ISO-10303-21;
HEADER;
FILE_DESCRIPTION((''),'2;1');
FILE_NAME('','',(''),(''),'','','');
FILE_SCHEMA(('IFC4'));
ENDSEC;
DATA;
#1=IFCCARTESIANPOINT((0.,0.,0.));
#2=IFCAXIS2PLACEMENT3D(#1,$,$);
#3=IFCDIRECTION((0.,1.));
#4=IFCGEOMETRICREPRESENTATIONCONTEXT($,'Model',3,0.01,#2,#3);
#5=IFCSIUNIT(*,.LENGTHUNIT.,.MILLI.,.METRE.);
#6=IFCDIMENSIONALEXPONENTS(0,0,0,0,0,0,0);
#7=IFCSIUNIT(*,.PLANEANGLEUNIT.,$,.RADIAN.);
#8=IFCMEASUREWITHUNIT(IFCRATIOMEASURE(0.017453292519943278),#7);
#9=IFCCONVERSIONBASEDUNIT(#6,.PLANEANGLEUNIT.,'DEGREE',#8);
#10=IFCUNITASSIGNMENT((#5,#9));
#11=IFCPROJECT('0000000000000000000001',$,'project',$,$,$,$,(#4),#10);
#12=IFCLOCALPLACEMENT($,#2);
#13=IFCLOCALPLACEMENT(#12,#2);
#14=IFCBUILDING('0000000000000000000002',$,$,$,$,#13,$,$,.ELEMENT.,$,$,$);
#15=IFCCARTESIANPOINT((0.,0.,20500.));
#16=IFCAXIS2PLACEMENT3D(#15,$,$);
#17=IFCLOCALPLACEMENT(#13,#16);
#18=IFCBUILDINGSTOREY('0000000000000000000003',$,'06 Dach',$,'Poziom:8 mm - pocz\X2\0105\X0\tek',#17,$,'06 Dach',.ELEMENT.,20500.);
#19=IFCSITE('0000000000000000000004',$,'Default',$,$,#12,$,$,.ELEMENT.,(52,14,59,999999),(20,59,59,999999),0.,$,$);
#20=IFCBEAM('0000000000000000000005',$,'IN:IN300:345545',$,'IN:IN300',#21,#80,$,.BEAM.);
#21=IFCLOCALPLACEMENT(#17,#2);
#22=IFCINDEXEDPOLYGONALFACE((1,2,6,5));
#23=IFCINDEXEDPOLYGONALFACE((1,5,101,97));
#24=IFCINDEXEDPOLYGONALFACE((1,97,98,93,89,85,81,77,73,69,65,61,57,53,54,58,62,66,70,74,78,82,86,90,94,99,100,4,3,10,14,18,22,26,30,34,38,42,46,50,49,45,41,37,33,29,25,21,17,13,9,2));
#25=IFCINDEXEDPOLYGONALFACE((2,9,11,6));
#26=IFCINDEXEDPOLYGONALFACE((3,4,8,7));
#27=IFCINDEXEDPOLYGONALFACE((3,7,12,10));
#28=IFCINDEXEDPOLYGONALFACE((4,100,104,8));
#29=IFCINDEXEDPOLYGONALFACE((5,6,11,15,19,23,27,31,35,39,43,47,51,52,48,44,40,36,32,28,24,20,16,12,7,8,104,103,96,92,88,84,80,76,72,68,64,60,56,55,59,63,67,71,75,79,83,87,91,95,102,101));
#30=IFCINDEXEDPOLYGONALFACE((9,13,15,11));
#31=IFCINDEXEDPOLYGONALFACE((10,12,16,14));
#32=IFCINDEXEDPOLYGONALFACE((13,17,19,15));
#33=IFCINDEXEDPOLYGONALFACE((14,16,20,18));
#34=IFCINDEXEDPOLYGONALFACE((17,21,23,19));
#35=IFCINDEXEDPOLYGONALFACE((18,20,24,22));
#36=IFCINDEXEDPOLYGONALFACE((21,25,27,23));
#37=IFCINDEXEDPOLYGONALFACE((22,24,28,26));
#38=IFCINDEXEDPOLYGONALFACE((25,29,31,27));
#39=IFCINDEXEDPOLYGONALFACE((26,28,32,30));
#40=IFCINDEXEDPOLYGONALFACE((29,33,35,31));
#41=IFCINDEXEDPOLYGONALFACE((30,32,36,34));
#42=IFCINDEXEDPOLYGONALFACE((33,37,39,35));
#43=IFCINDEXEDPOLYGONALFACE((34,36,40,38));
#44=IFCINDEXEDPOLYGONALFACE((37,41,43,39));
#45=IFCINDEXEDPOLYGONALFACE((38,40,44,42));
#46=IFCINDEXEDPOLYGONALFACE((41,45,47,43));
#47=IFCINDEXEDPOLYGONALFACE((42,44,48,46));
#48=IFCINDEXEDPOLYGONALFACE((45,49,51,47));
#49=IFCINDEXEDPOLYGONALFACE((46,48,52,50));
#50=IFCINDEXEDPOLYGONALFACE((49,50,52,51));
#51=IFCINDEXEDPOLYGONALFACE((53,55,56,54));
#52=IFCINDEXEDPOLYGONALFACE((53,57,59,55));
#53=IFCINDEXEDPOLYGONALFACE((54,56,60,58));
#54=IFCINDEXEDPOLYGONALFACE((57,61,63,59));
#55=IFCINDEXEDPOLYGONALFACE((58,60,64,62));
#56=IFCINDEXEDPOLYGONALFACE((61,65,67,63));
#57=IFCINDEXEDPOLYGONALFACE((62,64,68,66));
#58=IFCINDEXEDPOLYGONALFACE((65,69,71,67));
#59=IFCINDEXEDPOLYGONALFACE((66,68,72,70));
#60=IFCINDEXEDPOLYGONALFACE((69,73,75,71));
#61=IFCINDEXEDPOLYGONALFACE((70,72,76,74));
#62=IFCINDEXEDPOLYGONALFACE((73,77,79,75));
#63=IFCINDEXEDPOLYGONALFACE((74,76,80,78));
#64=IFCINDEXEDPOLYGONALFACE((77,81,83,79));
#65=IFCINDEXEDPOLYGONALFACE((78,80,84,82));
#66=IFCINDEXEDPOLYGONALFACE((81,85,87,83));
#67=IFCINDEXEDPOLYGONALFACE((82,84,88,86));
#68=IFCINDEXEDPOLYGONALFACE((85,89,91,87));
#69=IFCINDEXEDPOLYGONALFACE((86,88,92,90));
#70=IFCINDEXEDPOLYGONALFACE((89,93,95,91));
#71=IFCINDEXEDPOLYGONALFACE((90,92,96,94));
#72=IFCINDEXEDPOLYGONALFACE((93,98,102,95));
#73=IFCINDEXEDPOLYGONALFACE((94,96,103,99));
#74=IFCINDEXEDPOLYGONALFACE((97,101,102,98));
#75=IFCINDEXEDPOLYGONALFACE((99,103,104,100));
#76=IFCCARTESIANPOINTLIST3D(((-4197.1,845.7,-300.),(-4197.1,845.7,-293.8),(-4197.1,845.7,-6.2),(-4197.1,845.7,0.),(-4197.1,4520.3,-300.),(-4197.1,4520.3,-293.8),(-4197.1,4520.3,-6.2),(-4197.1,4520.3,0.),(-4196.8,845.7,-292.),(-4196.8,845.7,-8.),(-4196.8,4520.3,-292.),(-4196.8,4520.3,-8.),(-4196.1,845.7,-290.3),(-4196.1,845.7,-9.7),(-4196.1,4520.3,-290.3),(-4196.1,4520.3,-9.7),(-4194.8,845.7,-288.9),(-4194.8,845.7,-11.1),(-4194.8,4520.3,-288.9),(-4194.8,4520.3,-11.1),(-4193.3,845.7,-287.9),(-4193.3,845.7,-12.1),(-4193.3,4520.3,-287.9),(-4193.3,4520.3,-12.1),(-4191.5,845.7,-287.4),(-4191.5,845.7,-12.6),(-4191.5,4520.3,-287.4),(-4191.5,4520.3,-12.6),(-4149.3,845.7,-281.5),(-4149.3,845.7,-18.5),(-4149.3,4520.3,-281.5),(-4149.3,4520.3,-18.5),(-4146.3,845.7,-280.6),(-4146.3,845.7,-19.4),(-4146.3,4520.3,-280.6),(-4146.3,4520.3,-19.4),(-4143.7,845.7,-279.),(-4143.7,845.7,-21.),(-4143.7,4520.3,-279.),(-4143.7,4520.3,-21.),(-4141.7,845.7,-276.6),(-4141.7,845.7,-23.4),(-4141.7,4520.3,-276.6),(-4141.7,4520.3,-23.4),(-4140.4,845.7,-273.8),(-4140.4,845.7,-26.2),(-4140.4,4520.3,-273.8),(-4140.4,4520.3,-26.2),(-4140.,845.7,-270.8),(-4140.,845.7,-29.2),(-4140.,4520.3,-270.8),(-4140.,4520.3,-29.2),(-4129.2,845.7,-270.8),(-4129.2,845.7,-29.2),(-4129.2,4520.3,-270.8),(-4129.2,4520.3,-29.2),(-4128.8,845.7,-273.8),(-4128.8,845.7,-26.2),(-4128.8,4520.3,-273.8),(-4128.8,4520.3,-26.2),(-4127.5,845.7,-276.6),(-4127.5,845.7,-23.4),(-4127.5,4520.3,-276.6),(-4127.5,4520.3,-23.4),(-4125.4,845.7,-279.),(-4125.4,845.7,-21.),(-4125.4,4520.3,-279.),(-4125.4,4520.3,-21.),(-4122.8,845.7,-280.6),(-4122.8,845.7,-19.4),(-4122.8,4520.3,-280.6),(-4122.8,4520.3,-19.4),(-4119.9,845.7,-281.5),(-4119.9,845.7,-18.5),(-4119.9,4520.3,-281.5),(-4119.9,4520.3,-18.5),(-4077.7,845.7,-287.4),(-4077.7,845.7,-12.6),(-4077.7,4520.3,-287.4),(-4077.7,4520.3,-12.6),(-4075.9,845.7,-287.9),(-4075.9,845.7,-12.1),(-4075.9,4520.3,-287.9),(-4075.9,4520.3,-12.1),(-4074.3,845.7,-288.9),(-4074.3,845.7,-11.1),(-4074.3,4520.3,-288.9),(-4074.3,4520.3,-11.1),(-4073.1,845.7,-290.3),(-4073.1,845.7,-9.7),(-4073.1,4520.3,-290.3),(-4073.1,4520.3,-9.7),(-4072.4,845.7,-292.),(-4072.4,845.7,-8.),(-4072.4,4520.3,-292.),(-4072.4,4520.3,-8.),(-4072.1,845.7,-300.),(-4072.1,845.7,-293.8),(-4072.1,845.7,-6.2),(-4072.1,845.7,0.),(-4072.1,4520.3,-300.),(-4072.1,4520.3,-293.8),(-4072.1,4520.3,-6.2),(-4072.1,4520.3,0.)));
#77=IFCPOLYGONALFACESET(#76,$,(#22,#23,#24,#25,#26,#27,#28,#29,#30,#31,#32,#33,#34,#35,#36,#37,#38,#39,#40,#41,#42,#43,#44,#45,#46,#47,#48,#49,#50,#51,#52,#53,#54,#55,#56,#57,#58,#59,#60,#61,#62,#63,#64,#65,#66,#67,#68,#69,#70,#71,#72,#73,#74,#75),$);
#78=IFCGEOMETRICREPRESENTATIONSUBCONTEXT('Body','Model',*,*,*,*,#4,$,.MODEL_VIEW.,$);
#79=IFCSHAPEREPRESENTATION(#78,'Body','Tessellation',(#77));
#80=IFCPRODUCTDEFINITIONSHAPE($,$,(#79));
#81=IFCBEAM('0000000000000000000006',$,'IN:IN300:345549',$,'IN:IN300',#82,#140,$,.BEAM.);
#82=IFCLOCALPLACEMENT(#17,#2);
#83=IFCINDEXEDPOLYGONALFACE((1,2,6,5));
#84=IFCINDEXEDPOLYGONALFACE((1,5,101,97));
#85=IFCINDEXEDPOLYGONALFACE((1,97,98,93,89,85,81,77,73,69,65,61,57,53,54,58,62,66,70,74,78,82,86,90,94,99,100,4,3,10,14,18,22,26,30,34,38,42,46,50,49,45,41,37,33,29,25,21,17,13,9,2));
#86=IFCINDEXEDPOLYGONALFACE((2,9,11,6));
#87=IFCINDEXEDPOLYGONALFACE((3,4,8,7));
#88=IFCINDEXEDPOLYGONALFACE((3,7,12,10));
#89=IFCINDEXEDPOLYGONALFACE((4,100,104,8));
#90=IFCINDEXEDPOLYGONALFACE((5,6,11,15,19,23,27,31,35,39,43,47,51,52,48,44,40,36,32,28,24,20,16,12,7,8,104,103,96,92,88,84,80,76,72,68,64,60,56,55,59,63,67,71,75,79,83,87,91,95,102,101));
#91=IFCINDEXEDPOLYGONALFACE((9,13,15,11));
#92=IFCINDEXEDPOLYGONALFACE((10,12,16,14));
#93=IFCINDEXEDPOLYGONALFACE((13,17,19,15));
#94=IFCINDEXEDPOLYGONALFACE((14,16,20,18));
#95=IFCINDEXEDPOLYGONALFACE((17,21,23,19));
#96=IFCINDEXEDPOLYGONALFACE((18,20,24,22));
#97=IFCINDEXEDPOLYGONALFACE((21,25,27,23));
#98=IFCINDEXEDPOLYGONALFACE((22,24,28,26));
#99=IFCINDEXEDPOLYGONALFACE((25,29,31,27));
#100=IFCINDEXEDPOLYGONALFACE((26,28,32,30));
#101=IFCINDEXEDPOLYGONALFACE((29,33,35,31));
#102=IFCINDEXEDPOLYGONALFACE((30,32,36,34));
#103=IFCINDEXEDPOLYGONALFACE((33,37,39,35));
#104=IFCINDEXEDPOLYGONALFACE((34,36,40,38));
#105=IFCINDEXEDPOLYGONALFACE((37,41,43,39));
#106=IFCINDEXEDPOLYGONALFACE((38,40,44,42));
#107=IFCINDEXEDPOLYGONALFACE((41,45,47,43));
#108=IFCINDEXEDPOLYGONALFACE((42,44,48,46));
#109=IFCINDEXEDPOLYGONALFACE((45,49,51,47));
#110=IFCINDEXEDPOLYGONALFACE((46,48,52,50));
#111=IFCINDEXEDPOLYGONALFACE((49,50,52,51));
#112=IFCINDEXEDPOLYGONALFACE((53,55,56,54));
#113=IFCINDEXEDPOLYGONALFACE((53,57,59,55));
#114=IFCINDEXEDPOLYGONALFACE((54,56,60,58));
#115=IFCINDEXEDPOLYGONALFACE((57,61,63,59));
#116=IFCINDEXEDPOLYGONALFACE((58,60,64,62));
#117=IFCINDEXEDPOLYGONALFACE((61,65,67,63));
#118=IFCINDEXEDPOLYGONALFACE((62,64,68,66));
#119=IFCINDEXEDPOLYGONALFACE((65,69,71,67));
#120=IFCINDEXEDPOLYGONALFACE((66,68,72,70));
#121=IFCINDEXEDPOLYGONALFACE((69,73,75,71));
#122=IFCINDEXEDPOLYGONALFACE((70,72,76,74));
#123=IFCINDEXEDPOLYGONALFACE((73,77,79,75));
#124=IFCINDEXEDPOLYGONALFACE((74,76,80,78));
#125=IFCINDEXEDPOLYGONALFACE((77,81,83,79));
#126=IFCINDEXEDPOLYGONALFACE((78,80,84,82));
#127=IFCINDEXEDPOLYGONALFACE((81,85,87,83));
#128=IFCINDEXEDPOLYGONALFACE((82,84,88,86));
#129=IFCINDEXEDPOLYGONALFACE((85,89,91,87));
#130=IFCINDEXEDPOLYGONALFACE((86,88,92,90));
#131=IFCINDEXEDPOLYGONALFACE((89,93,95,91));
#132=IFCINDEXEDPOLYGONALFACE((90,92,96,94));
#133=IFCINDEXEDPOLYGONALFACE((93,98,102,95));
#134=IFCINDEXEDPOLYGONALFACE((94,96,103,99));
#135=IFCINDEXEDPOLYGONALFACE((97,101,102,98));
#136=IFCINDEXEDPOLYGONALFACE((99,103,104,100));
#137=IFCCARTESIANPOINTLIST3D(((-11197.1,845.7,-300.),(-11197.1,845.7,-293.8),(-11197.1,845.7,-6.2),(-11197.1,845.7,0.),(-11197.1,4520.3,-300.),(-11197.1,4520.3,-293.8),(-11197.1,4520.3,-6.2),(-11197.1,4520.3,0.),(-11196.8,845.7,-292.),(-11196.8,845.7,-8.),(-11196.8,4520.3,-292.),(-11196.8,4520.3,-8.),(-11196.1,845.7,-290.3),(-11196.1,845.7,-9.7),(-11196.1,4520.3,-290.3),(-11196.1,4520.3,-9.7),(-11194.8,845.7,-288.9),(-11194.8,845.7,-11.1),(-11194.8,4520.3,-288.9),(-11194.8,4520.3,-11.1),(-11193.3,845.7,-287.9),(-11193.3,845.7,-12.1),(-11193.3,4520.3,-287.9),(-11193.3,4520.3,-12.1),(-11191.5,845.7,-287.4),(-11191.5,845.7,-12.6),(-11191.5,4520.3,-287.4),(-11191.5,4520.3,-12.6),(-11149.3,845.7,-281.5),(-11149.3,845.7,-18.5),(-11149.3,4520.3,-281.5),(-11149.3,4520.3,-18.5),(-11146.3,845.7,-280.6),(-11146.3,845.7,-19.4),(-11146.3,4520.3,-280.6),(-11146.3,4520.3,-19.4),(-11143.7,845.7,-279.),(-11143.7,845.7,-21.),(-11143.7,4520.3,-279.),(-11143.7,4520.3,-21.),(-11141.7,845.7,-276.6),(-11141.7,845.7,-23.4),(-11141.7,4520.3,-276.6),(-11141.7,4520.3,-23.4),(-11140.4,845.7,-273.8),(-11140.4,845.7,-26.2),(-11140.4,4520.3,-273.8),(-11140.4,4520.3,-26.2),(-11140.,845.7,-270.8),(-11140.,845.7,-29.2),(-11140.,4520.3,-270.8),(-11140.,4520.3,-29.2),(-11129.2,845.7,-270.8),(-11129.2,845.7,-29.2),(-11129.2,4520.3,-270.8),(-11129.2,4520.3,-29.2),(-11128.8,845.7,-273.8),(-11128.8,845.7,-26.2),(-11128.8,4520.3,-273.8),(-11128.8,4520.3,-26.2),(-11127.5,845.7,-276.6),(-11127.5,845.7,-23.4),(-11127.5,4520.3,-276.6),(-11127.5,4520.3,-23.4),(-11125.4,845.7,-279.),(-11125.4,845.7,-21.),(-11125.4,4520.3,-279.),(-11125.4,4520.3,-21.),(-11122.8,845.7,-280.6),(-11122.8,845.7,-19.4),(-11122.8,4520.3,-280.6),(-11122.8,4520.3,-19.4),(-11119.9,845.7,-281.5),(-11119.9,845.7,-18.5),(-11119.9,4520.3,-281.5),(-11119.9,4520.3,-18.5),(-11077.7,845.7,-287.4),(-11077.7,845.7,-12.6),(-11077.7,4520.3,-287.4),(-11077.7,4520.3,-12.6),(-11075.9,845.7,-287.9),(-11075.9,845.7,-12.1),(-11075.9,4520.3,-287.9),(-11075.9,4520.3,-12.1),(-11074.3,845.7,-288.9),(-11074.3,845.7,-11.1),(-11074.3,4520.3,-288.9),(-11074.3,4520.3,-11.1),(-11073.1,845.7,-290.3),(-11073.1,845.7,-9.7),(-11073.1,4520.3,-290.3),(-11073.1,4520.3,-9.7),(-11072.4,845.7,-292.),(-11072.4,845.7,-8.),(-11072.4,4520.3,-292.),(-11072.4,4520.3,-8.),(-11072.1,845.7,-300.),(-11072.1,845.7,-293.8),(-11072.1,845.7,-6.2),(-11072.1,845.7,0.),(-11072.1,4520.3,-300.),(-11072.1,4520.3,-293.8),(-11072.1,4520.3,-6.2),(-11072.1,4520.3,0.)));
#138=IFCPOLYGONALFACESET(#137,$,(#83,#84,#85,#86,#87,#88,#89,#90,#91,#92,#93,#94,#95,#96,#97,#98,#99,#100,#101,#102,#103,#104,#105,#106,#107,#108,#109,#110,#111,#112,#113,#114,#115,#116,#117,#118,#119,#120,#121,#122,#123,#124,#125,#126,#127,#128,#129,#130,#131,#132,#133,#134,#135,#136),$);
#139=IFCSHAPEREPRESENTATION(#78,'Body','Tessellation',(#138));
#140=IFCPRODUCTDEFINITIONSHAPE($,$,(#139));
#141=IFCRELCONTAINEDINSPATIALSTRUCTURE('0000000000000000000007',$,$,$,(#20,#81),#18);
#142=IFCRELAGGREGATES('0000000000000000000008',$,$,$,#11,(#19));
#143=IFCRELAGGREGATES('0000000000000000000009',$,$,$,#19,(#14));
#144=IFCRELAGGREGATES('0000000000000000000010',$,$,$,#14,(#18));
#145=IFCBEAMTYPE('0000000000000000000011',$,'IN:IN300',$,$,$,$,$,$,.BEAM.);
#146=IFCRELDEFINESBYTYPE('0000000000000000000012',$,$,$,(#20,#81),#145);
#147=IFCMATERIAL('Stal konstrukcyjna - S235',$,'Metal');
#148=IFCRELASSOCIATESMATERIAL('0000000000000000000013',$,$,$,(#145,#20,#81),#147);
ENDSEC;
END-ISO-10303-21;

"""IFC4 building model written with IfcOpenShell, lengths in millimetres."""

from ifc_helpers import new_model, entity, si_unit, converted_unit, direction, frame, origin, place, context, subcontext, project, spatial, line, arc, indexed_curve, outline, extrude, source, transform, mapped, material, type_object, type_shapes, element, save


model = new_model("IFC4")

# Units and contexts
model_context = context("Model", 3, precision=0.01, world=origin(), true_north=direction((0.0, 1.0)))
body_context = subcontext(model_context, "Body", "Model", "MODEL_VIEW")
ifc_project = project(units=[si_unit("LENGTHUNIT", "METRE", prefix="MILLI"), converted_unit("PLANEANGLEUNIT", "DEGREE", entity("IfcRatioMeasure", 0.017453292519943278), si_unit("PLANEANGLEUNIT", "RADIAN"), dimensions=[0, 0, 0, 0, 0, 0, 0])], contexts=[model_context])

# Site, building, storey
site_placement = place(None, origin())
site = spatial("IfcSite", under=ifc_project, at=site_placement, Name="Default", CompositionType="ELEMENT", RefLatitude=(52, 14, 59, 999999), RefLongitude=(20, 59, 59, 999999), RefElevation=0.0)
building_placement = place(site_placement, origin())
building = spatial("IfcBuilding", under=site, at=building_placement, CompositionType="ELEMENT")
storey_placement = place(building_placement, frame((0.0, 0.0, 20500.0)))
storey = spatial("IfcBuildingStorey", under=building, at=storey_placement, Name="06 Dach", ObjectType="Poziom:8 mm - początek", LongName="06 Dach", CompositionType="ELEMENT", Elevation=20500.0)

# Beams
ifc_material = material(Name="Stal konstrukcyjna - S235", Category="Metal")
beam_type_1 = type_object("IfcBeamType", Name="IN:IN300", PredefinedType="BEAM", material=ifc_material)
shared_shape_1 = source(origin(), body_context, "Body", "SweptSolid", [
    extrude(outline(indexed_curve([(143.8, -62.5), (150.0, -62.5), (150.0, 62.5), (143.8, 62.5), (139.6, 60.9), (137.4, 56.9), (131.5, 14.7), (127.9, 8.1), (120.8, 5.4), (-120.8, 5.4), (-127.9, 8.1), (-131.5, 14.7), (-137.4, 56.9), (-139.6, 60.9), (-143.8, 62.5), (-150.0, 62.5), (-150.0, -62.5), (-143.8, -62.5), (-139.6, -60.9), (-137.4, -56.9), (-131.5, -14.7), (-127.9, -8.1), (-120.8, -5.4), (120.8, -5.4), (127.9, -8.1), (131.5, -14.7), (137.4, -56.9), (139.6, -60.9)], segments=[line(1, 2, 3, 4), arc(4, 5, 6), line(6, 7), arc(7, 8, 9), line(9, 10), arc(10, 11, 12), line(12, 13), arc(13, 14, 15), line(15, 16, 17, 18), arc(18, 19, 20), line(20, 21), arc(21, 22, 23), line(23, 24), arc(24, 25, 26), line(26, 27), arc(27, 28, 1)], self_intersect=False)), frame((-1837.3, 0.0, 0.0), z_axis=(1.0, 0.0, 0.0), x_axis=(0.0, 0.0, -1.0)), (0.0, 0.0, 1.0), 3674.6),
])
type_shapes(beam_type_1, [shared_shape_1])
for number, where, z_axis, x_axis, name in (
    (1, (-4134.6, 2683.0, -150.0), (0.0, 0.0, 1.0), (0.0, -1.0, 0.0), "IN:IN300:345545"),
    (2, (-11134.6, 2683.0, -150.0), (0.0, 0.0, 1.0), (0.0, -1.0, 0.0), "IN:IN300:345549"),
):
    element("IfcBeam", number, at=place(storey_placement, frame(where, z_axis=z_axis, x_axis=x_axis)), inside=storey, type_object=beam_type_1, material=ifc_material, Name=name, ObjectType="IN:IN300", PredefinedType="BEAM", context=body_context, shape_type="MappedRepresentation", body=[
        mapped(shared_shape_1, transform((0.0, 0.0, 0.0), scale=1.0)),
    ])

save(model, "model.ifc")
